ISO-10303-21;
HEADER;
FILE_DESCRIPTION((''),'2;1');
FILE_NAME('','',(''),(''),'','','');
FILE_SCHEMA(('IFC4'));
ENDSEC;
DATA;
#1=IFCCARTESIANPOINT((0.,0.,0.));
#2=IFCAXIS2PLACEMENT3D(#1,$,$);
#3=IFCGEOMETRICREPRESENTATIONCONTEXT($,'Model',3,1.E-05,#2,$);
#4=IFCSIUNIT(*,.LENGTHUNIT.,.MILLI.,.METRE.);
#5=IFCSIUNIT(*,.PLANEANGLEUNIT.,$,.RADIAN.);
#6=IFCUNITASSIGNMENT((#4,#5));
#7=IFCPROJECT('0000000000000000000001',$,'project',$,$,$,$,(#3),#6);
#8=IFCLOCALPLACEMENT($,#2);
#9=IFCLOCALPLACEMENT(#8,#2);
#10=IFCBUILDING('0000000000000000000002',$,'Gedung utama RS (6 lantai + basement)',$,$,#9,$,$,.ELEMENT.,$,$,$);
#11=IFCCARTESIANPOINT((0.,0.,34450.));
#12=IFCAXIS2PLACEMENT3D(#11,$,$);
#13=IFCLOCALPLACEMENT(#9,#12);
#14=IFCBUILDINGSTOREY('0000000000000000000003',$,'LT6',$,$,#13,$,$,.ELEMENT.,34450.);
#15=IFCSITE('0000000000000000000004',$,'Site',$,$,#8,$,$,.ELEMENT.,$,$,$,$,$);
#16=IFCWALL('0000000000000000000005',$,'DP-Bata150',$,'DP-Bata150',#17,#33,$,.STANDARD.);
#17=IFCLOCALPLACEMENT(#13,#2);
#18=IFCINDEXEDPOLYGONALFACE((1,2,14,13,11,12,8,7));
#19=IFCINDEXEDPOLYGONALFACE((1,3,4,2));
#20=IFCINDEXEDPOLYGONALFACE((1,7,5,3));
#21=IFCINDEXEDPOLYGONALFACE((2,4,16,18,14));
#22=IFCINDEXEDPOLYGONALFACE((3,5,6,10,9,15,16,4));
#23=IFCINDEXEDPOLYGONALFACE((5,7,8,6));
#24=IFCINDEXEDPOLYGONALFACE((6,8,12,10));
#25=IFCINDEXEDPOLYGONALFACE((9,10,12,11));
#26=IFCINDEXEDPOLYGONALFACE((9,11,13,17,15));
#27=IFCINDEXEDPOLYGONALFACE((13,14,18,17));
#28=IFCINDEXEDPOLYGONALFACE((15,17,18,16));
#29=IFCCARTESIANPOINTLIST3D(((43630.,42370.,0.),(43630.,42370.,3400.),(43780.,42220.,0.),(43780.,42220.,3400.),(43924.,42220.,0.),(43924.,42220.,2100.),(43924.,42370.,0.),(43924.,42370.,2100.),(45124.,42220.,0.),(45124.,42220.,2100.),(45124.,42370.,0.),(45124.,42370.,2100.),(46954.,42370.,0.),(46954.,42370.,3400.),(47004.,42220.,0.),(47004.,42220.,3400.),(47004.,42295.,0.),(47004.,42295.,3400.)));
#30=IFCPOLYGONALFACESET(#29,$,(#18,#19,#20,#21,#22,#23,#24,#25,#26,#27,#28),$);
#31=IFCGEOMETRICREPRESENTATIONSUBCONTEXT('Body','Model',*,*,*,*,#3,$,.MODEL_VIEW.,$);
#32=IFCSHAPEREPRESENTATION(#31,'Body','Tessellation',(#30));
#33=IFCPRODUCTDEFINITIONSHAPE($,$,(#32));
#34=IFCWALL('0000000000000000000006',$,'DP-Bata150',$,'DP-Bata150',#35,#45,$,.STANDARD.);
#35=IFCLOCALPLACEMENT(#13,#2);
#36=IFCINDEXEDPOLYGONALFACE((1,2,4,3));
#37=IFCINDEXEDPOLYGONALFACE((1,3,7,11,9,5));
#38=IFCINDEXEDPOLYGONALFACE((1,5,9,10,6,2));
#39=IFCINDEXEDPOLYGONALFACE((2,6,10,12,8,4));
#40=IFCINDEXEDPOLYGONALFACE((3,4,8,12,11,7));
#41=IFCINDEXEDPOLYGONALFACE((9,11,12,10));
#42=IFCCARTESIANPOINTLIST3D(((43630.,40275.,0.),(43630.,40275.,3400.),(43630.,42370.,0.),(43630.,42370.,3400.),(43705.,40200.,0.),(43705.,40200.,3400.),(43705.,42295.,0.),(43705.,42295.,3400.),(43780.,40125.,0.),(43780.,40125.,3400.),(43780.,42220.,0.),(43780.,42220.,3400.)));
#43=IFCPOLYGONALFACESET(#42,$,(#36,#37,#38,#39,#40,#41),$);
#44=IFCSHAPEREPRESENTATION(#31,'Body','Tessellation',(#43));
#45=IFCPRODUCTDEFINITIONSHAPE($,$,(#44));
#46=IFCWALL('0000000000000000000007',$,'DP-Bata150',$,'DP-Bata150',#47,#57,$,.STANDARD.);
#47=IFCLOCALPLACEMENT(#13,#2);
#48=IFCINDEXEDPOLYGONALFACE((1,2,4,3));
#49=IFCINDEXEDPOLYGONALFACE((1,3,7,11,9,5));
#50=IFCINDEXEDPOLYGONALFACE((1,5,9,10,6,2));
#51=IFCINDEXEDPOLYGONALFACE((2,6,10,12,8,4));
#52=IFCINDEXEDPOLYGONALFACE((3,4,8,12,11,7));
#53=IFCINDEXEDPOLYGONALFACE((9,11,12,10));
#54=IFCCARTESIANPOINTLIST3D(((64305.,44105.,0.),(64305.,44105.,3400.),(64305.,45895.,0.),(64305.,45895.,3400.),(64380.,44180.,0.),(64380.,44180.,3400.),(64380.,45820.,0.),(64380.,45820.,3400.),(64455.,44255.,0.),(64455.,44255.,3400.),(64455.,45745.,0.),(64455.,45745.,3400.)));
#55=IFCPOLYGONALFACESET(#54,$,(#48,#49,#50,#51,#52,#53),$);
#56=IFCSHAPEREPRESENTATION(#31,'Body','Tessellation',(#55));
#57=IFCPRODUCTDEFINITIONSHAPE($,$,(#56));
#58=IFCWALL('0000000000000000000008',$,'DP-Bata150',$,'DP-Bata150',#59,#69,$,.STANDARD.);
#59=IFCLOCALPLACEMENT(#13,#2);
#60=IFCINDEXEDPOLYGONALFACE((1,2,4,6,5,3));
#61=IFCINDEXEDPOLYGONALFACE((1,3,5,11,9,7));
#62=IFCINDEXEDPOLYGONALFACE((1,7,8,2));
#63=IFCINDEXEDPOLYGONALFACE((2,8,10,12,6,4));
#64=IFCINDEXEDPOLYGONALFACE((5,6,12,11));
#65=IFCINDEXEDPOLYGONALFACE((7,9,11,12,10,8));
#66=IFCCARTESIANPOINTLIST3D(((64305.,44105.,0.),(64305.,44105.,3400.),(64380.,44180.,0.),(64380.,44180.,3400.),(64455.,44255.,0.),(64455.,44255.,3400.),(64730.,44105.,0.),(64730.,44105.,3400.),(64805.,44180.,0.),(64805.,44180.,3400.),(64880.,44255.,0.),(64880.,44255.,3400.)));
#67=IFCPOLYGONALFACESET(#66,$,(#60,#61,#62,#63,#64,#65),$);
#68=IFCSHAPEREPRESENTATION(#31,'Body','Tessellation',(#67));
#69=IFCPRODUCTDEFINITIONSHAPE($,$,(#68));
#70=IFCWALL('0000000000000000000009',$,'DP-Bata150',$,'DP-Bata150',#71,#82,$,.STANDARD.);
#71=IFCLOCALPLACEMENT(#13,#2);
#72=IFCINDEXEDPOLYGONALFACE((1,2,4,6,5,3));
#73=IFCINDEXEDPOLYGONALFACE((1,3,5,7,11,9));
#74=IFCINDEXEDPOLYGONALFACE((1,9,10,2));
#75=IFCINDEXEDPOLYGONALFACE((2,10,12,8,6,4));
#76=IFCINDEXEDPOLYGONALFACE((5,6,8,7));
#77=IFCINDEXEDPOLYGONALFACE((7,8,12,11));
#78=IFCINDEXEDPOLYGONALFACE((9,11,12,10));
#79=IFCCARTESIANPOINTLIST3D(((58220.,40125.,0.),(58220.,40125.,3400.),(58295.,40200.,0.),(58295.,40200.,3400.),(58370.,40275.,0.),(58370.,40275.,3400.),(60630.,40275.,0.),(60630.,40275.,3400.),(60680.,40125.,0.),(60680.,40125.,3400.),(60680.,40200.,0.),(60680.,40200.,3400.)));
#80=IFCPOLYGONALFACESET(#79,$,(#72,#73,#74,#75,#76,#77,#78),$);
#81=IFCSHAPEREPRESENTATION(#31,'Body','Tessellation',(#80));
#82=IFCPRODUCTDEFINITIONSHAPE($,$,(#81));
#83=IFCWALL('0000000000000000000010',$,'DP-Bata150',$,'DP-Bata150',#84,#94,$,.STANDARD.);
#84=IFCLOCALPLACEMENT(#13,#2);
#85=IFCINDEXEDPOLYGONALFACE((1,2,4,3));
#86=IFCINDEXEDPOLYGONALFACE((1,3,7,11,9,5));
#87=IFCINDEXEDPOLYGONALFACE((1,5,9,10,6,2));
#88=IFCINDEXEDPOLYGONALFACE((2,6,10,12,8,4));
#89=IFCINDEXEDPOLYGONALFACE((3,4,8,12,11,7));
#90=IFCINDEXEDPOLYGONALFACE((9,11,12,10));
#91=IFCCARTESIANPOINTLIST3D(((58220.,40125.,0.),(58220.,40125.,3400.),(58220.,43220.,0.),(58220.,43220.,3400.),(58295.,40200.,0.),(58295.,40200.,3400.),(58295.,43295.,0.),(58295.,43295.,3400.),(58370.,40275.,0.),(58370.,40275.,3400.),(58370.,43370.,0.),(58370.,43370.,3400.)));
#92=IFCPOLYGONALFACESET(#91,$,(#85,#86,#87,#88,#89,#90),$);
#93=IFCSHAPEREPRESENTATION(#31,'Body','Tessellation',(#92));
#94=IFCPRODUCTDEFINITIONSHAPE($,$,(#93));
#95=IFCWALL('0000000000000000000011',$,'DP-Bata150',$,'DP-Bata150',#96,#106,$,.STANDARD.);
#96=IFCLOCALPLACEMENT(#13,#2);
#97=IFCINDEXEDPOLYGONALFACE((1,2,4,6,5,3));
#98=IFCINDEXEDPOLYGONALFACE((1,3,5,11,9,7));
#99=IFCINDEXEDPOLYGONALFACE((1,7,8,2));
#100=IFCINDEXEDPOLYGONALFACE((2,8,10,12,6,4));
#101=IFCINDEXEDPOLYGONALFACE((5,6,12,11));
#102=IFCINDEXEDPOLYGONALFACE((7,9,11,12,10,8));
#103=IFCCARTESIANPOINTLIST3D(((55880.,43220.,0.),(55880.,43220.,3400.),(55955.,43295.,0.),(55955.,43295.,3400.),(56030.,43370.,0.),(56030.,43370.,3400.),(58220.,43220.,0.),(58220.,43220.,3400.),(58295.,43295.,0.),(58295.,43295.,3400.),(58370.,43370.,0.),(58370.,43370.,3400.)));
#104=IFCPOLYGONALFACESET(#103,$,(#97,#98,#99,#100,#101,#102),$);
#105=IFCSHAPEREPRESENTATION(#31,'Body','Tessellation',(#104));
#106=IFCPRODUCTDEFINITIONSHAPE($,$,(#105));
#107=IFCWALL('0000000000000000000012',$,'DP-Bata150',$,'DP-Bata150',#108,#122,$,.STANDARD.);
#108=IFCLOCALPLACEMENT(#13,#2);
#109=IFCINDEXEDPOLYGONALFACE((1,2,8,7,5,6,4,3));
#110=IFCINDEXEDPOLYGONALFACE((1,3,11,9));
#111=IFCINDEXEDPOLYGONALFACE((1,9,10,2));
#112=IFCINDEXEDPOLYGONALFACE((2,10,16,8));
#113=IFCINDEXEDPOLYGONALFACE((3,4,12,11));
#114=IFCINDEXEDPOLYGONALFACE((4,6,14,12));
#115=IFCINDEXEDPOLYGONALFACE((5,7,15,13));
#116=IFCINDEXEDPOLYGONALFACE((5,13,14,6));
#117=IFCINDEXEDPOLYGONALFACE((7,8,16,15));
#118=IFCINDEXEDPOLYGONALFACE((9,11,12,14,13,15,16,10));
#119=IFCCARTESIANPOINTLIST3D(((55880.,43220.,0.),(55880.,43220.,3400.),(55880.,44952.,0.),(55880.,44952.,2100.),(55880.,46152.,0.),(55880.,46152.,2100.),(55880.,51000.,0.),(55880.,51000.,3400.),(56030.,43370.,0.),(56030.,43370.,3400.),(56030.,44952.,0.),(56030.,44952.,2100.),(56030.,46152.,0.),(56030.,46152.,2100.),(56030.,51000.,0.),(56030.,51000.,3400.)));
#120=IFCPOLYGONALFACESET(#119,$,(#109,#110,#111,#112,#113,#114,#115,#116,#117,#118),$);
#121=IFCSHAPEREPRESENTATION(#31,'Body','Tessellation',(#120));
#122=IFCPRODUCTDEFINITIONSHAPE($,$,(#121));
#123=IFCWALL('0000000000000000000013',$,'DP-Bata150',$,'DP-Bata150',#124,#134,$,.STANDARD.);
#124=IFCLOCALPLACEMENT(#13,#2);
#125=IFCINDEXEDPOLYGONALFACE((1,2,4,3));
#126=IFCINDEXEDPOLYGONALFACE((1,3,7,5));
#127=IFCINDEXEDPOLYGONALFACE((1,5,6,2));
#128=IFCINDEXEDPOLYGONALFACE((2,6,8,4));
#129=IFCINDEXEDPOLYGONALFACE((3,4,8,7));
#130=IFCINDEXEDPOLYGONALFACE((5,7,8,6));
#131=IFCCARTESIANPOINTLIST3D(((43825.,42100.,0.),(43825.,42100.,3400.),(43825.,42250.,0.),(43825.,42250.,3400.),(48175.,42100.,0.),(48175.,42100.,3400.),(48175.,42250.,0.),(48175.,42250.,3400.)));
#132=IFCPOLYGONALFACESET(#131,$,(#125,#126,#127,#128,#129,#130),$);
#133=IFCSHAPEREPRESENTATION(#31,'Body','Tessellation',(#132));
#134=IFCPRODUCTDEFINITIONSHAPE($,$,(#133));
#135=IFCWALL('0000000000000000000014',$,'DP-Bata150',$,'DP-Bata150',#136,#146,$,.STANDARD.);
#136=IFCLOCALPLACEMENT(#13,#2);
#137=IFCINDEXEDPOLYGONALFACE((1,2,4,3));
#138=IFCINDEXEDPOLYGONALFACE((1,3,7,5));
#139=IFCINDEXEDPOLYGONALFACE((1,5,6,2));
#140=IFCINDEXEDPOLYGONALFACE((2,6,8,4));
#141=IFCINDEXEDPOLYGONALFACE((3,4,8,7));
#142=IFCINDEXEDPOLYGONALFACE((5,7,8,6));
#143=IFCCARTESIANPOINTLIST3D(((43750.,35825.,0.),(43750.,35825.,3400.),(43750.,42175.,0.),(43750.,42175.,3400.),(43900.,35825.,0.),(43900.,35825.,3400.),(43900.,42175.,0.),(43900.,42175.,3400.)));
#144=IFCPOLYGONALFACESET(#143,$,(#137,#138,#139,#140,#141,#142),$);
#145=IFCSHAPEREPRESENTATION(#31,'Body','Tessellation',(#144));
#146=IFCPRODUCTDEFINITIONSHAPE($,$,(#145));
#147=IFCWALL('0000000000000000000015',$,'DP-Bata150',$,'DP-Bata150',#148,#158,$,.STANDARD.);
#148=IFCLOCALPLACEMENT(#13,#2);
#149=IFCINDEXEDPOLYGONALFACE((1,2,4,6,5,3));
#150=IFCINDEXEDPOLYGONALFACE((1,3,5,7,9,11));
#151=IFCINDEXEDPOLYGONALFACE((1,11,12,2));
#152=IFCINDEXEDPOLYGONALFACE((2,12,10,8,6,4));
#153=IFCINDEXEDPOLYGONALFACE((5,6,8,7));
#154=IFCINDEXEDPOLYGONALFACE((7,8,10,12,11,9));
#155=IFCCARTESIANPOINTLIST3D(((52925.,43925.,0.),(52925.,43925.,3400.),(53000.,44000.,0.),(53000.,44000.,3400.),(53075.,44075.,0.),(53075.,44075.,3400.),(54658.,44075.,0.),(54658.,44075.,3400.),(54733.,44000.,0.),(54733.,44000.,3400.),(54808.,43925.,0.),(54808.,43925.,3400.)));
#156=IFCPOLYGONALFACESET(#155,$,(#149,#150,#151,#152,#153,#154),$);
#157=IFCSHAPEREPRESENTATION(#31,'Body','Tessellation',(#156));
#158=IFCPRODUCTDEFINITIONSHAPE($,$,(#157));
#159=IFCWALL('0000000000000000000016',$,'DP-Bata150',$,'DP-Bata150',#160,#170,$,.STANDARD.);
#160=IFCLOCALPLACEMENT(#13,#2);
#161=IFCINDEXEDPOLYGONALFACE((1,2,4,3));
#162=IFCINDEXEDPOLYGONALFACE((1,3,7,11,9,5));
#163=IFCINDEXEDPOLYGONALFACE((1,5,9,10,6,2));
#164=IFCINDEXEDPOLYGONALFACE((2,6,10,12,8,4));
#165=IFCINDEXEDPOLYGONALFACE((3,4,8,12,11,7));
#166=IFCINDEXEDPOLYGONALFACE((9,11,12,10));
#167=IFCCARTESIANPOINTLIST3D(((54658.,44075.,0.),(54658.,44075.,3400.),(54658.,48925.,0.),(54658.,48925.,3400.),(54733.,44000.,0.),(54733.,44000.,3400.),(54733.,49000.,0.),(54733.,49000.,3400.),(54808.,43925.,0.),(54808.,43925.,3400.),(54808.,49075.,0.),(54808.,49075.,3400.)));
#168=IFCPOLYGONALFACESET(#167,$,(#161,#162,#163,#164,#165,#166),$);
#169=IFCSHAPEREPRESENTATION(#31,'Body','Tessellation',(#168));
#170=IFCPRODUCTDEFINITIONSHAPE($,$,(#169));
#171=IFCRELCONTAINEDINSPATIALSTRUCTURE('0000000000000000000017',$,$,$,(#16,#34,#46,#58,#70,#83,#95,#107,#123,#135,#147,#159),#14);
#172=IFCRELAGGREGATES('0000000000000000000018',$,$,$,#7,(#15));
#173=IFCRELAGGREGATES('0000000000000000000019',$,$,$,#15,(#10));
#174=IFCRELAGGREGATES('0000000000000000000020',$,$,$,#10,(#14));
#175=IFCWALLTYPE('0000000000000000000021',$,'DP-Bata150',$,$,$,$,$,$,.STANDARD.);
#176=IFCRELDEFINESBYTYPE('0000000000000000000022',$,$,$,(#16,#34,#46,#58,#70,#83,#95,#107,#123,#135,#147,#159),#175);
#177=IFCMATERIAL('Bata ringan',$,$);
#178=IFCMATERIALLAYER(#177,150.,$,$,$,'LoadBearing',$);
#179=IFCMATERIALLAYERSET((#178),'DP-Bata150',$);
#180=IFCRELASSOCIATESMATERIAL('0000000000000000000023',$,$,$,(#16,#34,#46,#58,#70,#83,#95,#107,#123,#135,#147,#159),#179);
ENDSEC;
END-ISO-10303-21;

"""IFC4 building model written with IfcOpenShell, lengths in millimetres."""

from ifc_helpers import new_model, si_unit, frame, frame_2d, origin, place, context, subcontext, project, spatial, polyline, rectangle, outline, extrude, material, layer, layer_set, layer_usage, type_object, element, save


model = new_model("IFC4")

# Units and contexts
model_context = context("Model", 3, precision=1e-05, world=origin())
body_context = subcontext(model_context, "Body", "Model", "MODEL_VIEW")
ifc_project = project(units=[si_unit("LENGTHUNIT", "METRE", prefix="MILLI"), si_unit("PLANEANGLEUNIT", "RADIAN")], contexts=[model_context])

# Site, building, storey
site_placement = place(None, origin())
site = spatial("IfcSite", under=ifc_project, at=site_placement, Name="Site", CompositionType="ELEMENT")
building_placement = place(site_placement, origin())
building = spatial("IfcBuilding", under=site, at=building_placement, Name="Gedung utama RS (6 lantai + basement)", CompositionType="ELEMENT")
storey_placement = place(building_placement, frame((0.0, 0.0, 34450.0)))
storey = spatial("IfcBuildingStorey", under=building, at=storey_placement, Name="LT6", CompositionType="ELEMENT", Elevation=34450.0)

# Shared definitions
ifc_material_1 = material(Name="Bata ringan")
ifc_layer_1 = layer(ifc_material_1, 150.0, Category="LoadBearing")
ifc_layer_set_1 = layer_set([ifc_layer_1], Name="DP-Bata150")
ifc_layer_usage_1 = layer_usage(ifc_layer_set_1, "AXIS2", "NEGATIVE", 75.0)
wall_type_1 = type_object("IfcWallType", Name="DP-Bata150", PredefinedType="STANDARD")

# Wall, opening
wall_1_placement = place(storey_placement, frame((47004.0, 42295.0, 0.0), z_axis=(0.0, 0.0, 1.0), x_axis=(-1.0, 0.0, 0.0)))
wall_1 = element("IfcWall", 1, at=wall_1_placement, inside=storey, type_object=wall_type_1, material=ifc_layer_usage_1, Name="DP-Bata150", ObjectType="DP-Bata150", PredefinedType="STANDARD", context=body_context, shape_type="SweptSolid", body=[
    extrude(outline(polyline([(50.0, -75.0), (0.0, 0.0), (0.0, 75.0), (3224.0, 75.0), (3299.0, 0.0), (3374.0, -75.0), (50.0, -75.0)])), origin(), (0.0, 0.0, 1.0), 3400.0),
])
opening_1_placement = place(wall_1_placement, frame((1880.0, 0.0, 0.0), z_axis=(0.0, 0.0, 1.0), x_axis=(1.0, 0.0, 0.0)))
element("IfcOpeningElement", 2, at=opening_1_placement, cuts=wall_1, PredefinedType="OPENING", context=body_context, shape_type="SweptSolid", body=[
    extrude(rectangle(XDim=1200.0, YDim=170.0, at=frame_2d((600.0, 0.0))), origin(), (0.0, 0.0, 1.0), 2100.0),
])

# Walls
wall_2_placement = place(storey_placement, frame((43705.0, 42295.0, 0.0), z_axis=(0.0, 0.0, 1.0), x_axis=(0.0, -1.0, 0.0)))
element("IfcWall", 3, at=wall_2_placement, inside=storey, type_object=wall_type_1, material=ifc_layer_usage_1, Name="DP-Bata150", ObjectType="DP-Bata150", PredefinedType="STANDARD", context=body_context, shape_type="SweptSolid", body=[
    extrude(outline(polyline([(-75.0, -75.0), (0.0, 0.0), (75.0, 75.0), (2170.0, 75.0), (2095.0, 0.0), (2020.0, -75.0), (-75.0, -75.0)])), origin(), (0.0, 0.0, 1.0), 3400.0),
])
wall_3_placement = place(storey_placement, frame((64380.0, 45820.0, 0.0), z_axis=(0.0, 0.0, 1.0), x_axis=(0.0, -1.0, 0.0)))
element("IfcWall", 4, at=wall_3_placement, inside=storey, type_object=wall_type_1, material=ifc_layer_usage_1, Name="DP-Bata150", ObjectType="DP-Bata150", PredefinedType="STANDARD", context=body_context, shape_type="SweptSolid", body=[
    extrude(outline(polyline([(-75.0, -75.0), (0.0, 0.0), (75.0, 75.0), (1565.0, 75.0), (1640.0, 0.0), (1715.0, -75.0), (-75.0, -75.0)])), origin(), (0.0, 0.0, 1.0), 3400.0),
])
wall_4_placement = place(storey_placement, frame((64380.0, 44180.0, 0.0), z_axis=(0.0, 0.0, 1.0), x_axis=(1.0, 0.0, 0.0)))
element("IfcWall", 5, at=wall_4_placement, inside=storey, type_object=wall_type_1, material=ifc_layer_usage_1, Name="DP-Bata150", ObjectType="DP-Bata150", PredefinedType="STANDARD", context=body_context, shape_type="SweptSolid", body=[
    extrude(outline(polyline([(-75.0, -75.0), (0.0, 0.0), (75.0, 75.0), (500.0, 75.0), (425.0, 0.0), (350.0, -75.0), (-75.0, -75.0)])), origin(), (0.0, 0.0, 1.0), 3400.0),
])
wall_5_placement = place(storey_placement, frame((60680.0, 40200.0, 0.0), z_axis=(0.0, 0.0, 1.0), x_axis=(-1.0, 0.0, 0.0)))
element("IfcWall", 6, at=wall_5_placement, inside=storey, type_object=wall_type_1, material=ifc_layer_usage_1, Name="DP-Bata150", ObjectType="DP-Bata150", PredefinedType="STANDARD", context=body_context, shape_type="SweptSolid", body=[
    extrude(outline(polyline([(50.0, -75.0), (0.0, 0.0), (0.0, 75.0), (2460.0, 75.0), (2385.0, 0.0), (2310.0, -75.0), (50.0, -75.0)])), origin(), (0.0, 0.0, 1.0), 3400.0),
])
wall_6_placement = place(storey_placement, frame((58295.0, 40200.0, 0.0), z_axis=(0.0, 0.0, 1.0), x_axis=(0.0, 1.0, 0.0)))
element("IfcWall", 7, at=wall_6_placement, inside=storey, type_object=wall_type_1, material=ifc_layer_usage_1, Name="DP-Bata150", ObjectType="DP-Bata150", PredefinedType="STANDARD", context=body_context, shape_type="SweptSolid", body=[
    extrude(outline(polyline([(75.0, -75.0), (0.0, 0.0), (-75.0, 75.0), (3020.0, 75.0), (3095.0, 0.0), (3170.0, -75.0), (75.0, -75.0)])), origin(), (0.0, 0.0, 1.0), 3400.0),
])
wall_7_placement = place(storey_placement, frame((58295.0, 43295.0, 0.0), z_axis=(0.0, 0.0, 1.0), x_axis=(-1.0, 0.0, 0.0)))
element("IfcWall", 8, at=wall_7_placement, inside=storey, type_object=wall_type_1, material=ifc_layer_usage_1, Name="DP-Bata150", ObjectType="DP-Bata150", PredefinedType="STANDARD", context=body_context, shape_type="SweptSolid", body=[
    extrude(outline(polyline([(-75.0, -75.0), (0.0, 0.0), (75.0, 75.0), (2415.0, 75.0), (2340.0, 0.0), (2265.0, -75.0), (-75.0, -75.0)])), origin(), (0.0, 0.0, 1.0), 3400.0),
])

# Wall, opening
wall_8_placement = place(storey_placement, frame((55955.0, 43295.0, 0.0), z_axis=(0.0, 0.0, 1.0), x_axis=(0.0, 1.0, 0.0)))
wall_8 = element("IfcWall", 9, at=wall_8_placement, inside=storey, type_object=wall_type_1, material=ifc_layer_usage_1, Name="DP-Bata150", ObjectType="DP-Bata150", PredefinedType="STANDARD", context=body_context, shape_type="SweptSolid", body=[
    extrude(outline(polyline([(75.0, -75.0), (0.0, 0.0), (-75.0, 75.0), (7705.0, 75.0), (7705.0, -75.0), (75.0, -75.0)])), origin(), (0.0, 0.0, 1.0), 3400.0),
])
opening_2_placement = place(wall_8_placement, frame((1657.0, 0.0, 0.0), z_axis=(0.0, 0.0, 1.0), x_axis=(1.0, 0.0, 0.0)))
element("IfcOpeningElement", 10, at=opening_2_placement, cuts=wall_8, PredefinedType="OPENING", context=body_context, shape_type="SweptSolid", body=[
    extrude(rectangle(XDim=1200.0, YDim=170.0, at=frame_2d((600.0, 0.0))), origin(), (0.0, 0.0, 1.0), 2100.0),
])

# Walls
wall_9_placement = place(storey_placement, frame((48175.0, 42175.0, 0.0), z_axis=(0.0, 0.0, 1.0), x_axis=(-1.0, 0.0, 0.0)))
element("IfcWall", 11, at=wall_9_placement, inside=storey, type_object=wall_type_1, material=ifc_layer_usage_1, Name="DP-Bata150", ObjectType="DP-Bata150", PredefinedType="STANDARD", context=body_context, shape_type="SweptSolid", body=[
    extrude(outline(polyline([(0.0, -75.0), (0.0, 75.0), (4350.0, 75.0), (4350.0, -75.0), (0.0, -75.0)])), origin(), (0.0, 0.0, 1.0), 3400.0),
])
wall_10_placement = place(storey_placement, frame((43825.0, 42175.0, 0.0), z_axis=(0.0, 0.0, 1.0), x_axis=(0.0, -1.0, 0.0)))
element("IfcWall", 12, at=wall_10_placement, inside=storey, type_object=wall_type_1, material=ifc_layer_usage_1, Name="DP-Bata150", ObjectType="DP-Bata150", PredefinedType="STANDARD", context=body_context, shape_type="SweptSolid", body=[
    extrude(outline(polyline([(0.0, -75.0), (0.0, 75.0), (6350.0, 75.0), (6350.0, -75.0), (0.0, -75.0)])), origin(), (0.0, 0.0, 1.0), 3400.0),
])
wall_11_placement = place(storey_placement, frame((53000.0, 44000.0, 0.0), z_axis=(0.0, 0.0, 1.0), x_axis=(1.0, 0.0, 0.0)))
element("IfcWall", 13, at=wall_11_placement, inside=storey, type_object=wall_type_1, material=ifc_layer_usage_1, Name="DP-Bata150", ObjectType="DP-Bata150", PredefinedType="STANDARD", context=body_context, shape_type="SweptSolid", body=[
    extrude(outline(polyline([(-75.0, -75.0), (0.0, 0.0), (75.0, 75.0), (1658.0, 75.0), (1733.0, 0.0), (1808.0, -75.0), (-75.0, -75.0)])), origin(), (0.0, 0.0, 1.0), 3400.0),
])
wall_12_placement = place(storey_placement, frame((54733.0, 44000.0, 0.0), z_axis=(0.0, 0.0, 1.0), x_axis=(0.0, 1.0, 0.0)))
element("IfcWall", 14, at=wall_12_placement, inside=storey, type_object=wall_type_1, material=ifc_layer_usage_1, Name="DP-Bata150", ObjectType="DP-Bata150", PredefinedType="STANDARD", context=body_context, shape_type="SweptSolid", body=[
    extrude(outline(polyline([(-75.0, -75.0), (0.0, 0.0), (75.0, 75.0), (4925.0, 75.0), (5000.0, 0.0), (5075.0, -75.0), (-75.0, -75.0)])), origin(), (0.0, 0.0, 1.0), 3400.0),
])

save(model, "model.ifc")
